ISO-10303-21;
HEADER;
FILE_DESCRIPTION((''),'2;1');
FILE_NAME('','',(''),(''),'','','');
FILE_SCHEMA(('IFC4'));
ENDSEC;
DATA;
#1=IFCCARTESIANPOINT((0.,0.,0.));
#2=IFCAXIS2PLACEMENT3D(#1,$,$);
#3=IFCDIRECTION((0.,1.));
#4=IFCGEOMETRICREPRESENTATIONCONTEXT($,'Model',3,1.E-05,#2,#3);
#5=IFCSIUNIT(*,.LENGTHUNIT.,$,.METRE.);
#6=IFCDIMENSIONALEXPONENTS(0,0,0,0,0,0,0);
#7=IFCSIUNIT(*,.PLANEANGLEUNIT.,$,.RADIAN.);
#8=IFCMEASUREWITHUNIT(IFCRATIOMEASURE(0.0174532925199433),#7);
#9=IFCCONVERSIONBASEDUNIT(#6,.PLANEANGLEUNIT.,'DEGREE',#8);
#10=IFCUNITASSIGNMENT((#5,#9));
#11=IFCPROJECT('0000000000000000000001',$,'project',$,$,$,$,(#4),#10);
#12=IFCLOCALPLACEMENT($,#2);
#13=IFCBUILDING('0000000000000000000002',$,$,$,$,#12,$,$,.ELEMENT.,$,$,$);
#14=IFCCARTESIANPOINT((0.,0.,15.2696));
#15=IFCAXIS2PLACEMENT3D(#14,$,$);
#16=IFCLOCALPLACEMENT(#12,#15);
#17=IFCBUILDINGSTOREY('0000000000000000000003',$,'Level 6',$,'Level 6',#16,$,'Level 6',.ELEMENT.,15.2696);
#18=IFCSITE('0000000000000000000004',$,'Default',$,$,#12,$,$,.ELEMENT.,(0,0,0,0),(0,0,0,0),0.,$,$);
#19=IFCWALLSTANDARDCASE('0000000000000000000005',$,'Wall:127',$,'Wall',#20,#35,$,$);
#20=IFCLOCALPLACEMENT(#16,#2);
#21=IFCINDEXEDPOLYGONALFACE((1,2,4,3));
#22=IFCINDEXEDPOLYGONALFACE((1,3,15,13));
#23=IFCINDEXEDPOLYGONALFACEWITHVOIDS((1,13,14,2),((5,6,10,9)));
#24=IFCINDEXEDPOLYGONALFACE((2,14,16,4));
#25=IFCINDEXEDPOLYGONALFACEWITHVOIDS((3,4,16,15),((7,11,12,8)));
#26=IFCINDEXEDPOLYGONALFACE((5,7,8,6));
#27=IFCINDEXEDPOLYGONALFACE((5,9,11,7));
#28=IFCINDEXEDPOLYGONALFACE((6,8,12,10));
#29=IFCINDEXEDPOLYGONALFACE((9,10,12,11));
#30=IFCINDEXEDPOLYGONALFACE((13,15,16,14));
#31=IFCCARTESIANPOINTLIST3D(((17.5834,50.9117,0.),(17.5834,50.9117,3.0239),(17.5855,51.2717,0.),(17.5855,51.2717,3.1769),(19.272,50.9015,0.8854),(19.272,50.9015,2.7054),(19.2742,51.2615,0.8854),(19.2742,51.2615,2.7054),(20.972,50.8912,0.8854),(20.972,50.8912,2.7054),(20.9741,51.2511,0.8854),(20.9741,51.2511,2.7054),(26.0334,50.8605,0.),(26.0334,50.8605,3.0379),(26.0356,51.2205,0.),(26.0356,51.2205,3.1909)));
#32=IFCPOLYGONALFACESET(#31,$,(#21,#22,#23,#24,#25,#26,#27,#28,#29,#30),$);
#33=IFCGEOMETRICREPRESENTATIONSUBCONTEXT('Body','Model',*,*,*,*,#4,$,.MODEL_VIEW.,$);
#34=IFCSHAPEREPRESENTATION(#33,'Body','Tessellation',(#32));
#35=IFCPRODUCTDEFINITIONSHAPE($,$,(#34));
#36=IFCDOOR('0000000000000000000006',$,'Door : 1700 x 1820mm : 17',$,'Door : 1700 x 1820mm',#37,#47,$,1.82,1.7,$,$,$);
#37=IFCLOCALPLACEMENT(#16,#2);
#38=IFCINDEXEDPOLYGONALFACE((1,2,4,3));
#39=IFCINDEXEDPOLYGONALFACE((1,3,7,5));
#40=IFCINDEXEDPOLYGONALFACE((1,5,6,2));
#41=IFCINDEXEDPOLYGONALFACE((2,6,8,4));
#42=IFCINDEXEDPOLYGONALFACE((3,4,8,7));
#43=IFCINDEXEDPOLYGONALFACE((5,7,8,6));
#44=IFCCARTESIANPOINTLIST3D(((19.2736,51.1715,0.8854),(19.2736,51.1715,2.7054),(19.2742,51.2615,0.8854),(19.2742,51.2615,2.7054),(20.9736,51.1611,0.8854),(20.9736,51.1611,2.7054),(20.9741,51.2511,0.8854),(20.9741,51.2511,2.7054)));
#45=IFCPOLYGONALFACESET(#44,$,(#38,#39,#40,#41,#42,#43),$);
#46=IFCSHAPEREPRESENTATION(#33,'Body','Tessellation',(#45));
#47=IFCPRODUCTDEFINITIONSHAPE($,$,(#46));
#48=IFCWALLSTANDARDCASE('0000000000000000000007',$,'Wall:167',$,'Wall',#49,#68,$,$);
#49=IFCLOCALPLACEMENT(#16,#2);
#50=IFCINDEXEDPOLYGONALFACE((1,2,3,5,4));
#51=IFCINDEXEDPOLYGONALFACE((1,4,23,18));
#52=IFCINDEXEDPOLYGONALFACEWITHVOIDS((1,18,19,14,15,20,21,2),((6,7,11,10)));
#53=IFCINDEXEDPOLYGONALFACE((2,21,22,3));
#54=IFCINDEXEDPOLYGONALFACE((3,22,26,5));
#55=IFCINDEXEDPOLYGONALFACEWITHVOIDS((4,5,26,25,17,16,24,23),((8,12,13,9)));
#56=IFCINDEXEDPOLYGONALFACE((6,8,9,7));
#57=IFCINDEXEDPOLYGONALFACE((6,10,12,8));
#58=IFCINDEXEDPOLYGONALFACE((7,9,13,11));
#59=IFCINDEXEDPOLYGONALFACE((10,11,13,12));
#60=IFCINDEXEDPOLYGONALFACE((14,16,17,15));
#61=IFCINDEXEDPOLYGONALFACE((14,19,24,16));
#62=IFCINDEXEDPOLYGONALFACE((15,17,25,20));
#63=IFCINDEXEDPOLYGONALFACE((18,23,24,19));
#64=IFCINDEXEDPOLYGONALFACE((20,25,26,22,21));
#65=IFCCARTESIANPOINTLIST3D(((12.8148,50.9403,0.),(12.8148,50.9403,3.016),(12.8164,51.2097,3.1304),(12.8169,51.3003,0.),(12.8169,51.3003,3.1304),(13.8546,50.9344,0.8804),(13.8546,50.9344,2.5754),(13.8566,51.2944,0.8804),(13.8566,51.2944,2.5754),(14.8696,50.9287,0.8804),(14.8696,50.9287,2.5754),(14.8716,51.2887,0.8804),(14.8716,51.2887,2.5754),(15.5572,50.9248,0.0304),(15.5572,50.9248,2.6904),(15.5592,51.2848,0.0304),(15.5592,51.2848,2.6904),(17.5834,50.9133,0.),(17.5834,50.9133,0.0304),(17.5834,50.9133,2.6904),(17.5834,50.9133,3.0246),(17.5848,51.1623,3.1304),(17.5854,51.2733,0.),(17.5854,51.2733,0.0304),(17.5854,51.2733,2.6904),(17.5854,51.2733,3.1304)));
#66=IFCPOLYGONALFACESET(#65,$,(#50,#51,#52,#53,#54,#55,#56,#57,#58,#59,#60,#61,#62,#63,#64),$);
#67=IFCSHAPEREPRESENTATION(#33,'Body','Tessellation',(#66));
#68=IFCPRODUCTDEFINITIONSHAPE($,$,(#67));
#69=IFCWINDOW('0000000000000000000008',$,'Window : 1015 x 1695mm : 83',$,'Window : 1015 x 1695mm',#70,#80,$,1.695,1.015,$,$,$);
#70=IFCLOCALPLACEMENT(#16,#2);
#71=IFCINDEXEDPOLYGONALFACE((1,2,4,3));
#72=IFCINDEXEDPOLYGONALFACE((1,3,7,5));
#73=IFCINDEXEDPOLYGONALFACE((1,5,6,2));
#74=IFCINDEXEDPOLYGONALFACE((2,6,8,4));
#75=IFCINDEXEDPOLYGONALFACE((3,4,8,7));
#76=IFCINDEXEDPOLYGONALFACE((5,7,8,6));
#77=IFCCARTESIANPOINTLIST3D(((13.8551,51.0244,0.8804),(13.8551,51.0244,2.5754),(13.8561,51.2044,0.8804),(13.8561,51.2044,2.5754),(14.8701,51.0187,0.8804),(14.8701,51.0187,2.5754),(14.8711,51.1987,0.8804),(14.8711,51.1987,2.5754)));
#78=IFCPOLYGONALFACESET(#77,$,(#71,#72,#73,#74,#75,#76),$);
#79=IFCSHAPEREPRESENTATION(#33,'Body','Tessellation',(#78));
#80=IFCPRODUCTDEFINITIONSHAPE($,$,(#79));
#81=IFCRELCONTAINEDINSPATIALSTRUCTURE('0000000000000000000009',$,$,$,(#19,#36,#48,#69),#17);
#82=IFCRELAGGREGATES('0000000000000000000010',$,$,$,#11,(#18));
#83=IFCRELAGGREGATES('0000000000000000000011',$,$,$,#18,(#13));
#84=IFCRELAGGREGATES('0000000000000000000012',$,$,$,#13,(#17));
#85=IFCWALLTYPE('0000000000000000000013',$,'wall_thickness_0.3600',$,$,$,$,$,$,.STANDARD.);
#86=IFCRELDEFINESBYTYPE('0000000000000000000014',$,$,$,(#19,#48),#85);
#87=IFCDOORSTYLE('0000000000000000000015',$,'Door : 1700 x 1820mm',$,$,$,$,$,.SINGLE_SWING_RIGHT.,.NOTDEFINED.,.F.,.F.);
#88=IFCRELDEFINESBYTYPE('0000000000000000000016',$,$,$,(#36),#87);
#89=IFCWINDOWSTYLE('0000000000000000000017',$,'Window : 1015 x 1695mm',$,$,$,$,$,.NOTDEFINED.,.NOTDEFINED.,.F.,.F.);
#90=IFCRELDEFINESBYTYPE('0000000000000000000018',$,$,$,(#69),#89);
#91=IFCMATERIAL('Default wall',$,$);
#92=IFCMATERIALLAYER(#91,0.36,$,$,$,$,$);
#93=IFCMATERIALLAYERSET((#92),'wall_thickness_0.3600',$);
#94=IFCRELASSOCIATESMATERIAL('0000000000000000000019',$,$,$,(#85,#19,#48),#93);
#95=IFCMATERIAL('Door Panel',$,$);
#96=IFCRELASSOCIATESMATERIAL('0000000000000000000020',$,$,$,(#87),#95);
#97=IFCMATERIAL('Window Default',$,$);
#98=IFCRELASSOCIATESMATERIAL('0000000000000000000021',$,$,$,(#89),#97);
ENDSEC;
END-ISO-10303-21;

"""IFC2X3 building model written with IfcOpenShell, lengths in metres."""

from ifc_helpers import new_model, entity, si_unit, converted_unit, direction, frame, frame_2d, origin, origin_2d_with_axis, place, context, subcontext, project, spatial, polyline, rectangle, outline, extrude, clip, halfspace, source, transform, mapped, material, layer, layer_set, layer_usage, type_object, type_shapes, element, fill, save


model = new_model("IFC2X3")

# Units and contexts
model_context = context("Model", 3, precision=1e-05, world=origin(), true_north=direction((0.0, 1.0)))
body_context = subcontext(model_context, "Body", "Model", "MODEL_VIEW")
ifc_project = project(units=[si_unit("LENGTHUNIT", "METRE"), converted_unit("PLANEANGLEUNIT", "DEGREE", entity("IfcRatioMeasure", 0.0174532925199433), si_unit("PLANEANGLEUNIT", "RADIAN"), dimensions=[0, 0, 0, 0, 0, 0, 0])], contexts=[model_context])

# Site, building, storey
placement = place(None, origin())
site = spatial("IfcSite", under=ifc_project, at=placement, Name="Default", CompositionType="ELEMENT", RefLatitude=(0, 0, 0, 0), RefLongitude=(0, 0, 0, 0), RefElevation=0.0)
building = spatial("IfcBuilding", under=site, at=placement, CompositionType="ELEMENT")
storey_placement = place(placement, frame((0.0, 0.0, 15.2696)))
storey = spatial("IfcBuildingStorey", under=building, at=storey_placement, Name="Level 6", ObjectType="Level 6", LongName="Level 6", CompositionType="ELEMENT", Elevation=15.2696)

# Shared definitions
ifc_material_1 = material(Name="Default wall")

# Shared definitions
ifc_material_2 = material(Name="Door Panel")
ifc_material_3 = material(Name="Window Default")

# Wall, opening, door
ifc_layer_1 = layer(ifc_material_1, 0.36)
ifc_layer_set_1 = layer_set([ifc_layer_1], Name="wall_thickness_0.3600")
ifc_layer_usage_1 = layer_usage(ifc_layer_set_1, "AXIS2", "POSITIVE", -0.18)
wall_type_1 = type_object("IfcWallType", Name="wall_thickness_0.3600", PredefinedType="STANDARD", material=ifc_layer_set_1)
wall_1_placement = place(storey_placement, frame((17.5845, 51.0917, 0.0), z_axis=(0.0, 0.0, 1.0), x_axis=(0.999982, -0.006063, 0.0)))
wall_1 = element("IfcWallStandardCase", 1, at=wall_1_placement, inside=storey, type_object=wall_type_1, material=ifc_layer_usage_1, Name="Wall:127", ObjectType="Wall", context=body_context, shape_type="Clipping", body=[
    clip(extrude(outline(polyline([(8.4502, -0.18), (8.4502, 0.18), (0.0, 0.18), (0.0, -0.18), (8.4502, -0.18)])), origin(), (0.0, 0.0, 1.0), 5.0854), halfspace(frame((-30.3778, 6.5315, 5.8261), z_axis=(-0.001517, -0.391127, 0.920336), x_axis=(0.999998, -0.002087, 0.000761)), False)),
])
opening_1_placement = place(wall_1_placement, frame((1.6887, -0.18, 0.8854)))
opening_1 = element("IfcOpeningElement", 2, at=opening_1_placement, cuts=wall_1, ObjectType="Opening", context=body_context, shape_type="SweptSolid", body=[
    extrude(rectangle(XDim=1.7, YDim=1.82, at=frame_2d((0.91, 0.85), x_axis=(0.0, 1.0))), frame((0.0, 0.0, 0.0), z_axis=(0.0, 1.0, 0.0), x_axis=(0.0, 0.0, 1.0)), (0.0, 0.0, 1.0), 0.36),
])
door_style_1 = type_object("IfcDoorStyle", Name="Door : 1700 x 1820mm", ConstructionType="NOTDEFINED", OperationType="SINGLE_SWING_RIGHT", ParameterTakesPrecedence=False, Sizeable=False, material=ifc_material_2)
shared_shape_1 = source(origin(), body_context, "Body", "SweptSolid", [
    extrude(rectangle(XDim=0.09, YDim=1.7, at=origin_2d_with_axis()), frame((0.85, 0.315, 0.0), z_axis=(0.0, 0.0, 1.0), x_axis=(0.0, 1.0, 0.0)), (0.0, 0.0, 1.0), 1.82),
])
type_shapes(door_style_1, [shared_shape_1])
door_1_placement = place(opening_1_placement, origin())
door_1 = element("IfcDoor", 3, at=door_1_placement, inside=storey, type_object=door_style_1, Name="Door : 1700 x 1820mm : 17", ObjectType="Door : 1700 x 1820mm", OverallHeight=1.82, OverallWidth=1.7, context=body_context, shape_type="MappedRepresentation", body=[
    mapped(shared_shape_1, transform((0.0, 0.0, 0.0), scale=1.0)),
])
fill(opening_1, door_1)

# Wall, openings, window
wall_2_placement = place(storey_placement, frame((12.8159, 51.1203, 0.0), z_axis=(0.0, 0.0, 1.0), x_axis=(0.999984, -0.005664, 0.0)))
wall_2 = element("IfcWallStandardCase", 4, at=wall_2_placement, inside=storey, type_object=wall_type_1, material=ifc_layer_usage_1, Name="Wall:167", ObjectType="Wall", context=body_context, shape_type="Clipping", body=[
    clip(extrude(outline(polyline([(4.7686, -0.18), (4.7686, 0.18), (0.0, 0.18), (0.0, -0.18), (4.7686, -0.18)])), origin(), (0.0, 0.0, 1.0), 3.1304), halfspace(frame((-25.6065, 6.542, 5.8261), z_axis=(-0.001673, -0.391126, 0.920336), x_axis=(0.999997, -0.002486, 0.000761)), False)),
])
opening_2_placement = place(wall_2_placement, frame((2.7424, -0.18, 0.0304)))
element("IfcOpeningElement", 5, at=opening_2_placement, cuts=wall_2, ObjectType="Opening", context=body_context, shape_type="SweptSolid", body=[
    extrude(rectangle(XDim=2.11, YDim=2.66, at=frame_2d((1.33, 1.055), x_axis=(0.0, 1.0))), frame((0.0, 0.0, 0.0), z_axis=(0.0, 1.0, 0.0), x_axis=(0.0, 0.0, 1.0)), (0.0, 0.0, 1.0), 0.36),
])
opening_3_placement = place(wall_2_placement, frame((1.0398, -0.18, 0.8804)))
opening_3 = element("IfcOpeningElement", 6, at=opening_3_placement, cuts=wall_2, ObjectType="Opening", context=body_context, shape_type="SweptSolid", body=[
    extrude(rectangle(XDim=1.015, YDim=1.695, at=frame_2d((0.8475, 0.5075), x_axis=(0.0, 1.0))), frame((0.0, 0.0, 0.0), z_axis=(0.0, 1.0, 0.0), x_axis=(0.0, 0.0, 1.0)), (0.0, 0.0, 1.0), 0.36),
])
window_style_1 = type_object("IfcWindowStyle", Name="Window : 1015 x 1695mm", ConstructionType="NOTDEFINED", OperationType="NOTDEFINED", ParameterTakesPrecedence=False, Sizeable=False, material=ifc_material_3)
shared_shape_2 = source(origin(), body_context, "Body", "SweptSolid", [
    extrude(rectangle(XDim=0.18, YDim=1.015, at=origin_2d_with_axis()), frame((0.5075, 0.18, 0.0), z_axis=(0.0, 0.0, 1.0), x_axis=(0.0, 1.0, 0.0)), (0.0, 0.0, 1.0), 1.695),
])
type_shapes(window_style_1, [shared_shape_2])
window_1_placement = place(opening_3_placement, origin())
window_1 = element("IfcWindow", 7, at=window_1_placement, inside=storey, type_object=window_style_1, Name="Window : 1015 x 1695mm : 83", ObjectType="Window : 1015 x 1695mm", OverallHeight=1.695, OverallWidth=1.015, context=body_context, shape_type="MappedRepresentation", body=[
    mapped(shared_shape_2, transform((0.0, 0.0, 0.0), scale=1.0)),
])
fill(opening_3, window_1)

save(model, "model.ifc")
